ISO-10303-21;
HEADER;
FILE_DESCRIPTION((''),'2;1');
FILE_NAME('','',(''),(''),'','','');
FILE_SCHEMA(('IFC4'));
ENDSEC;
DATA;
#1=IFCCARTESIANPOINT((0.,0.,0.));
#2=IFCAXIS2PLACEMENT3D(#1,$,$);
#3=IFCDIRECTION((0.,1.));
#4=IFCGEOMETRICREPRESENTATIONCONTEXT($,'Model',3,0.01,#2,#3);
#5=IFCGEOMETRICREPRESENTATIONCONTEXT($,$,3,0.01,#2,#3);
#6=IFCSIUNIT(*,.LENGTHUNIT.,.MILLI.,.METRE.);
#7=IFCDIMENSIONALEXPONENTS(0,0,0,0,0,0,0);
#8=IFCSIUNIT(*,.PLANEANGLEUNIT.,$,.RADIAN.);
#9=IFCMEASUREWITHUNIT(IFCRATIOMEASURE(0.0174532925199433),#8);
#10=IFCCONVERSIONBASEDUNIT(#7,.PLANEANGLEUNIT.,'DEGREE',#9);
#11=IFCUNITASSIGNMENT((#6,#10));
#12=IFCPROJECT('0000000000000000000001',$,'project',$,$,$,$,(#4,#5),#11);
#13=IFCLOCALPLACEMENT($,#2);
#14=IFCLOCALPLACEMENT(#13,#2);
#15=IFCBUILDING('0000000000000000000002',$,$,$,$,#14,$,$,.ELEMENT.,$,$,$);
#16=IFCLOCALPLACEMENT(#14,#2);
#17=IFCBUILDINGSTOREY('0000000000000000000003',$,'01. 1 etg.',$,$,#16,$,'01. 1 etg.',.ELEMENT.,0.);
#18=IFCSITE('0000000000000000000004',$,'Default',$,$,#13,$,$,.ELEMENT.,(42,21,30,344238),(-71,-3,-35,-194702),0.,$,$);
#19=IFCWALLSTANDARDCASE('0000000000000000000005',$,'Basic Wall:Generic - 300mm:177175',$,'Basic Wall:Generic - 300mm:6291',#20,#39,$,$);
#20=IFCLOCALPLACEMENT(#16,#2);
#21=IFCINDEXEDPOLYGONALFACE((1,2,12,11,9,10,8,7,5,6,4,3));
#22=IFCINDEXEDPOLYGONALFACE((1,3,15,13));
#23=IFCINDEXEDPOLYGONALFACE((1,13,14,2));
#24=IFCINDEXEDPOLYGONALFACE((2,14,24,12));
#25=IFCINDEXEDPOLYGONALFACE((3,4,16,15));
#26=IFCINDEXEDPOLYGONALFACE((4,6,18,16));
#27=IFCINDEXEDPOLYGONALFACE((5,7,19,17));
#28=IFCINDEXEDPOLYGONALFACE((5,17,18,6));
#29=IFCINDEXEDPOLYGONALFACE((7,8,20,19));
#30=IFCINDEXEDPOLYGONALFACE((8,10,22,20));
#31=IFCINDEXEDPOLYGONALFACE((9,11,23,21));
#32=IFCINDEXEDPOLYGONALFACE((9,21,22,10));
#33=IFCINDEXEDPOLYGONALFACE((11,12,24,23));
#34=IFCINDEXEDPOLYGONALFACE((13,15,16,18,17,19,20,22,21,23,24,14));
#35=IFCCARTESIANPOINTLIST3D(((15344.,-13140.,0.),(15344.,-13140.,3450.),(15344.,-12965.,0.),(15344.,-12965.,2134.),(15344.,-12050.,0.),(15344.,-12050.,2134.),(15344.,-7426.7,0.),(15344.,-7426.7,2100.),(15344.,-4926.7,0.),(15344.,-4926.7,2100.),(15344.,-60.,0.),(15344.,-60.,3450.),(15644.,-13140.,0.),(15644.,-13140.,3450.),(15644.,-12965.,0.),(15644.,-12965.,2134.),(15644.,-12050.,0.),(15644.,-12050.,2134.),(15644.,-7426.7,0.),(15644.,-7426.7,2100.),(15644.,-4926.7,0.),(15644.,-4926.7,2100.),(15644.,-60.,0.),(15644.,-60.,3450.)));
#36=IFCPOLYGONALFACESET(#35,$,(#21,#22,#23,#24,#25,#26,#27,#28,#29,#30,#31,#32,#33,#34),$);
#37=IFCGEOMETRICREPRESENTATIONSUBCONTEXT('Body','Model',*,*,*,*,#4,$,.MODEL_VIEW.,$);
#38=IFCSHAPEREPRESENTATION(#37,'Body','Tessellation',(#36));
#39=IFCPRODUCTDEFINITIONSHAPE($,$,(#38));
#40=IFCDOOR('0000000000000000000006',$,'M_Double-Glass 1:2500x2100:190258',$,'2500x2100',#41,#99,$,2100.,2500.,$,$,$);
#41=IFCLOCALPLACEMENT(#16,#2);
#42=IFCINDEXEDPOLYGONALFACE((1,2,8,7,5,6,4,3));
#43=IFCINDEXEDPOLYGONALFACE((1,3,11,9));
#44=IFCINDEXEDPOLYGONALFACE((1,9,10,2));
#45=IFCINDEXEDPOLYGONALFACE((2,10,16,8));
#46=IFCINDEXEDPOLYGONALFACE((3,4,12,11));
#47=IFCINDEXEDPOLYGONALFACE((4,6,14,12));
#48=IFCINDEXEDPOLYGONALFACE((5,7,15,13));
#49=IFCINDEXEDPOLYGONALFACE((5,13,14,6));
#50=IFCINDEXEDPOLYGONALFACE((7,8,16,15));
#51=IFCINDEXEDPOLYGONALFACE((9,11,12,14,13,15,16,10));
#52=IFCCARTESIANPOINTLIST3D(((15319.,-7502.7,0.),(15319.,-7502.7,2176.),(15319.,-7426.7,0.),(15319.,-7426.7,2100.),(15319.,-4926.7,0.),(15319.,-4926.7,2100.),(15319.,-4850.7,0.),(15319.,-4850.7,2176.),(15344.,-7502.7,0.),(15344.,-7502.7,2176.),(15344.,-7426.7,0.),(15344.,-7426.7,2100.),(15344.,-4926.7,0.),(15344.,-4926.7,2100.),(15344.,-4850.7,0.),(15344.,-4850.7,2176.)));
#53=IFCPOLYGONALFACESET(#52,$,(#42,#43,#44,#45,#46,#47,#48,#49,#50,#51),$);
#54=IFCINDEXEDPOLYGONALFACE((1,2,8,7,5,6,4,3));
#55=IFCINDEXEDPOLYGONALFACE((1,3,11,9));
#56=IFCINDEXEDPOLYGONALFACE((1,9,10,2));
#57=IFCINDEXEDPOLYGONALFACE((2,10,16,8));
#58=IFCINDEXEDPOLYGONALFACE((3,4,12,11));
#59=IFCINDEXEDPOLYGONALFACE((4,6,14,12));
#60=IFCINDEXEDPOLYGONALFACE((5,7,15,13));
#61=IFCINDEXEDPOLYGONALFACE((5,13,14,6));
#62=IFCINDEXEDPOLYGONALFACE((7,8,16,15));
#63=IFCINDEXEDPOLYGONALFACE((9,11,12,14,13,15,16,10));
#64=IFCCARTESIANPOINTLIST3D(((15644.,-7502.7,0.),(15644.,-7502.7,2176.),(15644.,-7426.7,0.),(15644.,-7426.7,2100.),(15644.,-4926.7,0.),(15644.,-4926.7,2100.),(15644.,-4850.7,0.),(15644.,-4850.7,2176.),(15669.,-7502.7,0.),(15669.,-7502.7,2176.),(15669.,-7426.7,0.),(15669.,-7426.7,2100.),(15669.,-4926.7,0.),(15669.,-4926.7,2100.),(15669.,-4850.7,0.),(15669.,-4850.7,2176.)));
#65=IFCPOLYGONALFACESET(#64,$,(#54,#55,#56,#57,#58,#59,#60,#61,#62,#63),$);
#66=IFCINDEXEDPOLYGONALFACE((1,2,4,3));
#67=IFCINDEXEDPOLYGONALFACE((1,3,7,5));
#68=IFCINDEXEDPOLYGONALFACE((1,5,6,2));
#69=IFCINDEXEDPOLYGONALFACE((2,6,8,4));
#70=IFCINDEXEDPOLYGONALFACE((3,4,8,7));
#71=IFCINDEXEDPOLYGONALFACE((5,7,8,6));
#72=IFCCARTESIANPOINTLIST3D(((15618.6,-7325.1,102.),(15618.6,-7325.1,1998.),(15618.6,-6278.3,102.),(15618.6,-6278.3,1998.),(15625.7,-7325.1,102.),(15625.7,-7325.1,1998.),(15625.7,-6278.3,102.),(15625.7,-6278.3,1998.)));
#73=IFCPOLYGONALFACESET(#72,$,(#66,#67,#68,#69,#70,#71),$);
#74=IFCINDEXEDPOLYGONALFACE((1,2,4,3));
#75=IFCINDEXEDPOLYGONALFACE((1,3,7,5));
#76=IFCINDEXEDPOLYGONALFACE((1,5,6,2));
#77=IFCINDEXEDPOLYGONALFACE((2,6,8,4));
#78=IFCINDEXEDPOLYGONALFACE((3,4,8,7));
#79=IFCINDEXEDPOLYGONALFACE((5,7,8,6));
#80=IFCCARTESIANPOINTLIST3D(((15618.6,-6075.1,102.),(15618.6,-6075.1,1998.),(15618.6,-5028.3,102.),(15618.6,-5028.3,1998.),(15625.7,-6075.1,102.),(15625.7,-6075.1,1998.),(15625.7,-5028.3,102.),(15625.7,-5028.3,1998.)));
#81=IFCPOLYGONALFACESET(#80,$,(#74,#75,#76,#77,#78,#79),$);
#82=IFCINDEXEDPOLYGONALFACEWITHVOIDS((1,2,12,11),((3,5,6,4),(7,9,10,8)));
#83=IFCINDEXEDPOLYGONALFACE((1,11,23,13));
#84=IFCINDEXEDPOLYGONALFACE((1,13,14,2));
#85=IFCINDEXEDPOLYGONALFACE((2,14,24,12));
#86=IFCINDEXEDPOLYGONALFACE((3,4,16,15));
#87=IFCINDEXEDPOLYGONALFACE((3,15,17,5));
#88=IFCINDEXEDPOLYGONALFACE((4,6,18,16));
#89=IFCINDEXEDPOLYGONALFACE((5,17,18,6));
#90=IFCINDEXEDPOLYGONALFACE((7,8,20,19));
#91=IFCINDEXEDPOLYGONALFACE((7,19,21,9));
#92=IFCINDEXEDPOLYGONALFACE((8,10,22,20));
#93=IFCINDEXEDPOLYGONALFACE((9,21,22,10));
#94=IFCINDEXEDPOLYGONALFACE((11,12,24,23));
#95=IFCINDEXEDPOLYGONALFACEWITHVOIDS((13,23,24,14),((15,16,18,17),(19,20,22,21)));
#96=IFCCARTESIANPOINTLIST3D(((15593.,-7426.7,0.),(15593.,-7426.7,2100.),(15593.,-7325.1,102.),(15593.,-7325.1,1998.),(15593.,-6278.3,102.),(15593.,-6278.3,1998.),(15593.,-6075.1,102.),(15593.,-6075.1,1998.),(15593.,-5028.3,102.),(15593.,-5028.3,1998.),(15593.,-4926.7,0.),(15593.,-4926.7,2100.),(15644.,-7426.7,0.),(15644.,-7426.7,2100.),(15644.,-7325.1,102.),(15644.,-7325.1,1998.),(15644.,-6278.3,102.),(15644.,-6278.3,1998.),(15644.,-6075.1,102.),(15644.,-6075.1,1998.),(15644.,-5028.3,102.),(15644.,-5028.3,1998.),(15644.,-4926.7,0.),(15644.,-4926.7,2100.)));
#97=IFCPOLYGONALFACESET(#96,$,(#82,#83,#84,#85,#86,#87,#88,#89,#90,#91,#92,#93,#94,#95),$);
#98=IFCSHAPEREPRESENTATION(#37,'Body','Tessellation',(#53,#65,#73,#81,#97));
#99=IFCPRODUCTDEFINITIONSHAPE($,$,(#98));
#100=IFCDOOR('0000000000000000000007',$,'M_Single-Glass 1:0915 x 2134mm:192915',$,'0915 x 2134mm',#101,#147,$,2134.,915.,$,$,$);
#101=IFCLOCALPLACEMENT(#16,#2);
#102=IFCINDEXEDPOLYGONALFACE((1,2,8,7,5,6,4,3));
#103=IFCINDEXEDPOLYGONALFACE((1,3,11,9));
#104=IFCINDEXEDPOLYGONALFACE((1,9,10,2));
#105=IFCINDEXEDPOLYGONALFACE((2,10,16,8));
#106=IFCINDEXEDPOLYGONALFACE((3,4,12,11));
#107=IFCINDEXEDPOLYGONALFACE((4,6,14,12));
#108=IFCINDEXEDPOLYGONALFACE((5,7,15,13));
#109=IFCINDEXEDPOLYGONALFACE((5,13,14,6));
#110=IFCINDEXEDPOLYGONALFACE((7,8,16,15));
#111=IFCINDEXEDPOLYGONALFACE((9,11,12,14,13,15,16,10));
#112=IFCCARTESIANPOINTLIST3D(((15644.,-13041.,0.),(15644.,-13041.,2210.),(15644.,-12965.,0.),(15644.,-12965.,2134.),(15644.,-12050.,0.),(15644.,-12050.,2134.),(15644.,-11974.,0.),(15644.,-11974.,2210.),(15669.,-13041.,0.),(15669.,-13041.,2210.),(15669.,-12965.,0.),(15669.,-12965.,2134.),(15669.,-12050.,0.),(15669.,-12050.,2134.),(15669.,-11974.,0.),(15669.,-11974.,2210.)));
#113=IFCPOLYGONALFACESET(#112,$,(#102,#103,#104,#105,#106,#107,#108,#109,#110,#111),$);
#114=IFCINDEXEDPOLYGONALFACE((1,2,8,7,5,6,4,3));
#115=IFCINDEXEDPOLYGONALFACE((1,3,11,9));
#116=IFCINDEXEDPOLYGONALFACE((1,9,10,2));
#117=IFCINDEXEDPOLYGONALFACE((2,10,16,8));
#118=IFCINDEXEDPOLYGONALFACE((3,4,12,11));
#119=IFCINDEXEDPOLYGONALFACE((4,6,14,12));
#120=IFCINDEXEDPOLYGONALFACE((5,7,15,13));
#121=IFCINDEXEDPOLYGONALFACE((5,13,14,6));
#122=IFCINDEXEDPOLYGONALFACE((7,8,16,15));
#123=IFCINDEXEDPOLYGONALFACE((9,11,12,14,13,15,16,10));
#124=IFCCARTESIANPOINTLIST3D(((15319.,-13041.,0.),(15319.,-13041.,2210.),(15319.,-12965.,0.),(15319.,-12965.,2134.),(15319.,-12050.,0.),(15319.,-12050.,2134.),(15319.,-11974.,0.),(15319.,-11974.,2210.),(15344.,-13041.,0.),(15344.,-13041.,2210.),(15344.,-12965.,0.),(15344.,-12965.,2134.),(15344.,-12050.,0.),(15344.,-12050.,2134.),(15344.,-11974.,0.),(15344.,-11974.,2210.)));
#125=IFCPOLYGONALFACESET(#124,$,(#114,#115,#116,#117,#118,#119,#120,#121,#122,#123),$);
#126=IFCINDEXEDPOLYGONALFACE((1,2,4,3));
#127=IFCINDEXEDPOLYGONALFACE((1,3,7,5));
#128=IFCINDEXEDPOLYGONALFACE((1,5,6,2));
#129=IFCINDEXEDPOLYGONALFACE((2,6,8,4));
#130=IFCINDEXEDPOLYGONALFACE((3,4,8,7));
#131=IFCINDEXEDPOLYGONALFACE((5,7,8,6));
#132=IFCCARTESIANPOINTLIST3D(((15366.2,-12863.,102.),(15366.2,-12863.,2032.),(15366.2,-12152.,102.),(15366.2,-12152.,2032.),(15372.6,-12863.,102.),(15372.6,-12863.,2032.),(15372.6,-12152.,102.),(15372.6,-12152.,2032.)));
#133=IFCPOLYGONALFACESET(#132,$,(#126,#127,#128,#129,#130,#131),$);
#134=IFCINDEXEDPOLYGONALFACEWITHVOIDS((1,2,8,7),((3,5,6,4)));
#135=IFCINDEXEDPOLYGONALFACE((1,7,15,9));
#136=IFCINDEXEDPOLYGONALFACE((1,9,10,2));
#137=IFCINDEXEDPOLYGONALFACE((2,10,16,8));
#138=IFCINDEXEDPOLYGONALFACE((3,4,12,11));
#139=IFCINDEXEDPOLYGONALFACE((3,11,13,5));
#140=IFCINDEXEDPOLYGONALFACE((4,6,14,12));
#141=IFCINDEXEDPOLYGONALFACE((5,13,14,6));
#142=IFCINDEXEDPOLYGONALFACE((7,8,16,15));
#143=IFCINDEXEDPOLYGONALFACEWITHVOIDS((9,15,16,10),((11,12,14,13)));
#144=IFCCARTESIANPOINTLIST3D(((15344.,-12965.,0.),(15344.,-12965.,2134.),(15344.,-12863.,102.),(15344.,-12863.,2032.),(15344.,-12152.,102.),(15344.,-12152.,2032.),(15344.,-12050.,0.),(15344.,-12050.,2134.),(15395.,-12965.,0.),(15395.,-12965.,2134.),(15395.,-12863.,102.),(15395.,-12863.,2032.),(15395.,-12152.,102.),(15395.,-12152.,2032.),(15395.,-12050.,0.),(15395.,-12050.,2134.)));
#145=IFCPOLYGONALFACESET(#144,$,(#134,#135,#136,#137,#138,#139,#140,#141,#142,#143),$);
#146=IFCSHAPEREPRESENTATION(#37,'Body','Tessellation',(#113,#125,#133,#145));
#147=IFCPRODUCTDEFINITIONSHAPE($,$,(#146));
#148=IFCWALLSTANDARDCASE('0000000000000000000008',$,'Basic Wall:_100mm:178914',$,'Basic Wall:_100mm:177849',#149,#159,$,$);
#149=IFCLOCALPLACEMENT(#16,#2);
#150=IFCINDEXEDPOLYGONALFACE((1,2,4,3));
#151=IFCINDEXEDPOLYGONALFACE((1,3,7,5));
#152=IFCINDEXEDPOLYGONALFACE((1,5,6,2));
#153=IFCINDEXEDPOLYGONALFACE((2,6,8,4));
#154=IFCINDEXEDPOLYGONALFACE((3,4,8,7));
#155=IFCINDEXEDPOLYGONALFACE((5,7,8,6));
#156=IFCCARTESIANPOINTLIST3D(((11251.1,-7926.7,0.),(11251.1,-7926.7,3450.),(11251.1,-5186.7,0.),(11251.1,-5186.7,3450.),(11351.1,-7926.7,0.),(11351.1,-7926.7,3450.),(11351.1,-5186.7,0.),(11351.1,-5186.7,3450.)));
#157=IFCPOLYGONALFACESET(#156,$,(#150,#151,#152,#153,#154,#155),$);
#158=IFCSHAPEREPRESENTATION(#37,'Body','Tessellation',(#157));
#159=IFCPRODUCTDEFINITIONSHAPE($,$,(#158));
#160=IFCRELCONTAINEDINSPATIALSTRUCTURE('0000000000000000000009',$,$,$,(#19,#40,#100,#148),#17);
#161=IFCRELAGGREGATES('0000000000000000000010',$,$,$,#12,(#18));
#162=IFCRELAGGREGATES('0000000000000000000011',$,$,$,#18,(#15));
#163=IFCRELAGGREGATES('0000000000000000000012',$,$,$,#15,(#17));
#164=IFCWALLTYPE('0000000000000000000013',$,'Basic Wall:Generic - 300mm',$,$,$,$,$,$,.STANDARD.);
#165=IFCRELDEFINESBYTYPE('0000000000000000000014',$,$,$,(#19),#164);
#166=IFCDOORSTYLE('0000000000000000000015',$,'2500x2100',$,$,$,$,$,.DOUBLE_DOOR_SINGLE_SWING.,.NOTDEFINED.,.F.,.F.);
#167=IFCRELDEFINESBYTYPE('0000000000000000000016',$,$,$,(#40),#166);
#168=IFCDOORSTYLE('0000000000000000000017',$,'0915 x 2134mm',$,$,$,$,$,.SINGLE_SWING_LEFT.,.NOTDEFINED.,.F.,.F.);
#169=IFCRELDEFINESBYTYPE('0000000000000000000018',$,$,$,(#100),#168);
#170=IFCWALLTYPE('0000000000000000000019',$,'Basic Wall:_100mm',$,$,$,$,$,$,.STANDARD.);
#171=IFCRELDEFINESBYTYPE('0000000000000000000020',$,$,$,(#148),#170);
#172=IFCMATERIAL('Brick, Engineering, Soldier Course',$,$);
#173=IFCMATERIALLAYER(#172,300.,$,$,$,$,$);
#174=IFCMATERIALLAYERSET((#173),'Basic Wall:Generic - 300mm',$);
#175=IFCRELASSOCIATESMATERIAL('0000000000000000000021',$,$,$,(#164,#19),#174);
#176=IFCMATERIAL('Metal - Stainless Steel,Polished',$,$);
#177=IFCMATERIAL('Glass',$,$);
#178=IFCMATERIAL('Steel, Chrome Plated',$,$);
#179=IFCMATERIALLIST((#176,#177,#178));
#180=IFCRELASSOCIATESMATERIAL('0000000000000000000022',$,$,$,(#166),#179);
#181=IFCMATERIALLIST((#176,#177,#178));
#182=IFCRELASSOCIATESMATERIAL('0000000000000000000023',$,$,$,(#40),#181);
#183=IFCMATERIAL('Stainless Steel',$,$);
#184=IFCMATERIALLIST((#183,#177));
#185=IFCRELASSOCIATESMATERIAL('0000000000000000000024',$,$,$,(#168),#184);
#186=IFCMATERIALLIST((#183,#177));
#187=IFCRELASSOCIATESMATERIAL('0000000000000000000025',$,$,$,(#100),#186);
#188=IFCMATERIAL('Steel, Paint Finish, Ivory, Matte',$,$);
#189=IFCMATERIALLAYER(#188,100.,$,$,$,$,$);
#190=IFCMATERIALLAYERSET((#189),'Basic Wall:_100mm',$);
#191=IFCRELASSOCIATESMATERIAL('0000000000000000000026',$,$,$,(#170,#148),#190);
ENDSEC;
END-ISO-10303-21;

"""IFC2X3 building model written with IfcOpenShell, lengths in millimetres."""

from ifc_helpers import new_model, entity, si_unit, converted_unit, direction, frame, frame_2d, origin, origin_2d_with_axis, place, context, subcontext, project, spatial, polyline, rectangle, outline, extrude, clip, bounded_halfspace, source, transform, mapped, material, material_list, layer, layer_set, layer_usage, type_object, type_shapes, element, fill, save


model = new_model("IFC2X3")

# Units and contexts
model_context = context("Model", 3, precision=0.01, world=origin(), true_north=direction((0.0, 1.0)))
context_of_model = context(None, 3, precision=0.01, world=origin(), true_north=direction((0.0, 1.0)))
body_context = subcontext(model_context, "Body", "Model", "MODEL_VIEW")
ifc_project = project(units=[si_unit("LENGTHUNIT", "METRE", prefix="MILLI"), converted_unit("PLANEANGLEUNIT", "DEGREE", entity("IfcRatioMeasure", 0.0174532925199433), si_unit("PLANEANGLEUNIT", "RADIAN"), dimensions=[0, 0, 0, 0, 0, 0, 0])], contexts=[model_context, context_of_model])

# Site, building, storey
site_placement = place(None, origin())
site = spatial("IfcSite", under=ifc_project, at=site_placement, Name="Default", CompositionType="ELEMENT", RefLatitude=(42, 21, 30, 344238), RefLongitude=(-71, -3, -35, -194702), RefElevation=0.0)
building_placement = place(site_placement, origin())
building = spatial("IfcBuilding", under=site, at=building_placement, CompositionType="ELEMENT")
storey_placement = place(building_placement, origin())
storey = spatial("IfcBuildingStorey", under=building, at=storey_placement, Name="01. 1 etg.", LongName="01. 1 etg.", CompositionType="ELEMENT", Elevation=0.0)

# Shared definitions
ifc_material_1 = material(Name="Glass")

# Wall, openings, doors
ifc_material_2 = material(Name="Brick, Engineering, Soldier Course")
ifc_layer_1 = layer(ifc_material_2, 300.0)
ifc_layer_set_1 = layer_set([ifc_layer_1], Name="Basic Wall:Generic - 300mm")
ifc_layer_usage_1 = layer_usage(ifc_layer_set_1, "AXIS2", "POSITIVE", -150.0)
wall_type_1 = type_object("IfcWallType", Name="Basic Wall:Generic - 300mm", PredefinedType="STANDARD", material=ifc_layer_set_1)
wall_1_placement = place(storey_placement, frame((15494.0, -13140.0, 0.0), z_axis=(0.0, 0.0, 1.0), x_axis=(0.0, 1.0, 0.0)))
wall_1 = element("IfcWallStandardCase", 1, at=wall_1_placement, inside=storey, type_object=wall_type_1, material=ifc_layer_usage_1, Name="Basic Wall:Generic - 300mm:177175", ObjectType="Basic Wall:Generic - 300mm:6291", context=body_context, shape_type="Clipping", body=[
    clip(extrude(rectangle(XDim=13080.0, YDim=300.0, at=frame_2d((6540.0, 0.0), x_axis=(-1.0, 0.0))), origin(), (0.0, 0.0, 1.0), 3450.0), bounded_halfspace(frame((13080.0, 150.0, 3450.0), z_axis=(0.0, 0.0, -1.0), x_axis=(-1.0, 0.0, 0.0)), True, frame((13080.0, 150.0, 3450.0)), polyline([(0.0, 0.0), (-3490.0, 0.0), (-3590.0, 0.0), (-9490.0, 0.0), (-9590.0, 0.0), (-13080.0, 0.0), (-13080.0, -50.0), (-9490.0, -50.0), (-9490.0, -246.0), (-3590.0, -246.0), (0.0, -246.0), (0.0, 0.0)]))),
])
opening_1_placement = place(wall_1_placement, frame((8213.3, 150.0, 0.0)))
opening_1 = element("IfcOpeningElement", 2, at=opening_1_placement, cuts=wall_1, ObjectType="Opening", context=body_context, shape_type="SweptSolid", body=[
    extrude(rectangle(XDim=2500.0, YDim=2100.0, at=frame_2d((1050.0, 1250.0), x_axis=(0.0, 1.0))), frame((0.0, 0.0, 0.0), z_axis=(0.0, -1.0, 0.0), x_axis=(0.0, 0.0, 1.0)), (0.0, 0.0, 1.0), 300.0),
])
opening_2_placement = place(wall_1_placement, frame((175.0, -150.0, 0.0)))
opening_2 = element("IfcOpeningElement", 3, at=opening_2_placement, cuts=wall_1, ObjectType="Opening", context=body_context, shape_type="SweptSolid", body=[
    extrude(rectangle(XDim=915.0, YDim=2134.0, at=frame_2d((1067.0, 457.5), x_axis=(0.0, -1.0))), frame((0.0, 0.0, 0.0), z_axis=(0.0, 1.0, 0.0), x_axis=(0.0, 0.0, 1.0)), (0.0, 0.0, 1.0), 300.0),
])
ifc_material_3 = material(Name="Metal - Stainless Steel,Polished")
ifc_material_4 = material(Name="Steel, Chrome Plated")
ifc_material_list_1 = material_list([ifc_material_3, ifc_material_1, ifc_material_4])
ifc_material_list_2 = material_list([ifc_material_3, ifc_material_1, ifc_material_4])
door_style_1 = type_object("IfcDoorStyle", Name="2500x2100", ConstructionType="NOTDEFINED", OperationType="DOUBLE_DOOR_SINGLE_SWING", ParameterTakesPrecedence=False, Sizeable=False, material=ifc_material_list_2)
shared_shape_1 = source(origin(), body_context, "Body", "SweptSolid", [
    extrude(outline(polyline([(-1326.0, -1069.0), (-1250.0, -1069.0), (-1250.0, 1031.0), (1250.0, 1031.0), (1250.0, -1069.0), (1326.0, -1069.0), (1326.0, 1107.0), (-1326.0, 1107.0), (-1326.0, -1069.0)])), frame((1250.0, -25.0, 1069.0), z_axis=(0.0, 1.0, 0.0), x_axis=(-1.0, 0.0, 0.0)), (0.0, 0.0, 1.0), 25.0),
    extrude(outline(polyline([(-1250.0, -1031.0), (-1250.0, 1069.0), (-1326.0, 1069.0), (-1326.0, -1107.0), (1326.0, -1107.0), (1326.0, 1069.0), (1250.0, 1069.0), (1250.0, -1031.0), (-1250.0, -1031.0)])), frame((1250.0, 300.0, 1069.0), z_axis=(0.0, -1.0, 0.0), x_axis=(-1.0, 0.0, 0.0)), (0.0, 0.0, -1.0), 25.0),
    extrude(rectangle(XDim=7.1, YDim=1046.8, at=frame_2d((0.0, 0.0), x_axis=(1.0, 0.0))), frame((1875.0, 278.2, 102.0), z_axis=(0.0, 0.0, 1.0), x_axis=(0.0, 1.0, 0.0)), (0.0, 0.0, 1.0), 1896.0),
    extrude(rectangle(XDim=7.1, YDim=1046.8, at=frame_2d((0.0, 0.0), x_axis=(1.0, 0.0))), frame((625.0, 278.2, 102.0), z_axis=(0.0, 0.0, 1.0), x_axis=(0.0, 1.0, 0.0)), (0.0, 0.0, 1.0), 1896.0),
    extrude(outline(polyline([(-1050.0, -1250.0), (1050.0, -1250.0), (1050.0, 1250.0), (-1050.0, 1250.0), (-1050.0, -1250.0)]), holes=[polyline([(-948.0, 101.6), (-948.0, 1148.4), (948.0, 1148.4), (948.0, 101.6), (-948.0, 101.6)]), polyline([(-948.0, -1148.4), (-948.0, -101.6), (948.0, -101.6), (948.0, -1148.4), (-948.0, -1148.4)])]), frame((1250.0, 249.0, 1050.0), z_axis=(0.0, 1.0, 0.0), x_axis=(0.0, 0.0, -1.0)), (0.0, 0.0, 1.0), 51.0),
])
type_shapes(door_style_1, [shared_shape_1])
door_1_placement = place(opening_1_placement, frame((0.0, 0.0, 0.0), z_axis=(0.0, 0.0, 1.0), x_axis=(-1.0, 0.0, 0.0)))
door_1 = element("IfcDoor", 4, at=door_1_placement, inside=storey, type_object=door_style_1, material=ifc_material_list_1, Name="M_Double-Glass 1:2500x2100:190258", ObjectType="2500x2100", OverallHeight=2100.0, OverallWidth=2500.0, context=body_context, shape_type="MappedRepresentation", body=[
    mapped(shared_shape_1, transform((0.0, 0.0, 0.0), scale=1.0)),
])
fill(opening_1, door_1)
ifc_material_5 = material(Name="Stainless Steel")
ifc_material_list_3 = material_list([ifc_material_5, ifc_material_1])
ifc_material_list_4 = material_list([ifc_material_5, ifc_material_1])
door_style_2 = type_object("IfcDoorStyle", Name="0915 x 2134mm", ConstructionType="NOTDEFINED", OperationType="SINGLE_SWING_LEFT", ParameterTakesPrecedence=False, Sizeable=False, material=ifc_material_list_4)
shared_shape_2 = source(origin(), body_context, "Body", "SweptSolid", [
    extrude(outline(polyline([(-457.5, -1048.0), (-457.5, 1086.0), (-533.5, 1086.0), (-533.5, -1124.0), (533.5, -1124.0), (533.5, 1086.0), (457.5, 1086.0), (457.5, -1048.0), (-457.5, -1048.0)])), frame((457.5, 0.0, 1086.0), z_axis=(0.0, 1.0, 0.0), x_axis=(1.0, 0.0, 0.0)), (0.0, 0.0, -1.0), 25.0),
    extrude(outline(polyline([(-457.5, -1048.0), (-457.5, 1086.0), (-533.5, 1086.0), (-533.5, -1124.0), (533.5, -1124.0), (533.5, 1086.0), (457.5, 1086.0), (457.5, -1048.0), (-457.5, -1048.0)])), frame((457.5, 325.0, 1086.0), z_axis=(0.0, 1.0, 0.0), x_axis=(1.0, 0.0, 0.0)), (0.0, 0.0, -1.0), 25.0),
    extrude(rectangle(XDim=711.0, YDim=6.4, at=origin_2d_with_axis()), frame((457.5, 274.6, 102.0)), (0.0, 0.0, 1.0), 1930.0),
    extrude(outline(polyline([(-1067.0, -457.5), (1067.0, -457.5), (1067.0, 457.5), (-1067.0, 457.5), (-1067.0, -457.5)]), holes=[polyline([(-965.0, 355.5), (965.0, 355.5), (965.0, -355.5), (-965.0, -355.5), (-965.0, 355.5)])]), frame((457.5, 300.0, 1067.0), z_axis=(0.0, -1.0, 0.0), x_axis=(0.0, 0.0, -1.0)), (0.0, 0.0, 1.0), 51.0),
])
type_shapes(door_style_2, [shared_shape_2])
door_2_placement = place(opening_2_placement, origin())
door_2 = element("IfcDoor", 5, at=door_2_placement, inside=storey, type_object=door_style_2, material=ifc_material_list_3, Name="M_Single-Glass 1:0915 x 2134mm:192915", ObjectType="0915 x 2134mm", OverallHeight=2134.0, OverallWidth=915.0, context=body_context, shape_type="MappedRepresentation", body=[
    mapped(shared_shape_2, transform((0.0, 0.0, 0.0), scale=1.0)),
])
fill(opening_2, door_2)
ifc_material_6 = material(Name="Steel, Paint Finish, Ivory, Matte")
ifc_layer_2 = layer(ifc_material_6, 100.0)
ifc_layer_set_2 = layer_set([ifc_layer_2], Name="Basic Wall:_100mm")
wall_type_2 = type_object("IfcWallType", Name="Basic Wall:_100mm", PredefinedType="STANDARD", material=ifc_layer_set_2)

# Wall
ifc_layer_usage_2 = layer_usage(ifc_layer_set_2, "AXIS2", "NEGATIVE", 50.0)
wall_2_placement = place(storey_placement, frame((11301.1, -5186.7, 0.0), z_axis=(0.0, 0.0, 1.0), x_axis=(0.0, -1.0, 0.0)))
element("IfcWallStandardCase", 6, at=wall_2_placement, inside=storey, type_object=wall_type_2, material=ifc_layer_usage_2, Name="Basic Wall:_100mm:178914", ObjectType="Basic Wall:_100mm:177849", context=body_context, shape_type="Clipping", body=[
    clip(extrude(rectangle(XDim=2740.0, YDim=100.0, at=frame_2d((1370.0, 0.0), x_axis=(-1.0, 0.0))), origin(), (0.0, 0.0, 1.0), 3450.0), bounded_halfspace(frame((0.0, -50.0, 3450.0), z_axis=(0.0, 0.0, -1.0), x_axis=(1.0, 0.0, 0.0)), True, frame((0.0, -50.0, 3450.0)), polyline([(0.0, 0.0), (2740.0, 0.0), (2740.0, 100.0), (0.0, 100.0), (0.0, 0.0)]))),
])

save(model, "model.ifc")
